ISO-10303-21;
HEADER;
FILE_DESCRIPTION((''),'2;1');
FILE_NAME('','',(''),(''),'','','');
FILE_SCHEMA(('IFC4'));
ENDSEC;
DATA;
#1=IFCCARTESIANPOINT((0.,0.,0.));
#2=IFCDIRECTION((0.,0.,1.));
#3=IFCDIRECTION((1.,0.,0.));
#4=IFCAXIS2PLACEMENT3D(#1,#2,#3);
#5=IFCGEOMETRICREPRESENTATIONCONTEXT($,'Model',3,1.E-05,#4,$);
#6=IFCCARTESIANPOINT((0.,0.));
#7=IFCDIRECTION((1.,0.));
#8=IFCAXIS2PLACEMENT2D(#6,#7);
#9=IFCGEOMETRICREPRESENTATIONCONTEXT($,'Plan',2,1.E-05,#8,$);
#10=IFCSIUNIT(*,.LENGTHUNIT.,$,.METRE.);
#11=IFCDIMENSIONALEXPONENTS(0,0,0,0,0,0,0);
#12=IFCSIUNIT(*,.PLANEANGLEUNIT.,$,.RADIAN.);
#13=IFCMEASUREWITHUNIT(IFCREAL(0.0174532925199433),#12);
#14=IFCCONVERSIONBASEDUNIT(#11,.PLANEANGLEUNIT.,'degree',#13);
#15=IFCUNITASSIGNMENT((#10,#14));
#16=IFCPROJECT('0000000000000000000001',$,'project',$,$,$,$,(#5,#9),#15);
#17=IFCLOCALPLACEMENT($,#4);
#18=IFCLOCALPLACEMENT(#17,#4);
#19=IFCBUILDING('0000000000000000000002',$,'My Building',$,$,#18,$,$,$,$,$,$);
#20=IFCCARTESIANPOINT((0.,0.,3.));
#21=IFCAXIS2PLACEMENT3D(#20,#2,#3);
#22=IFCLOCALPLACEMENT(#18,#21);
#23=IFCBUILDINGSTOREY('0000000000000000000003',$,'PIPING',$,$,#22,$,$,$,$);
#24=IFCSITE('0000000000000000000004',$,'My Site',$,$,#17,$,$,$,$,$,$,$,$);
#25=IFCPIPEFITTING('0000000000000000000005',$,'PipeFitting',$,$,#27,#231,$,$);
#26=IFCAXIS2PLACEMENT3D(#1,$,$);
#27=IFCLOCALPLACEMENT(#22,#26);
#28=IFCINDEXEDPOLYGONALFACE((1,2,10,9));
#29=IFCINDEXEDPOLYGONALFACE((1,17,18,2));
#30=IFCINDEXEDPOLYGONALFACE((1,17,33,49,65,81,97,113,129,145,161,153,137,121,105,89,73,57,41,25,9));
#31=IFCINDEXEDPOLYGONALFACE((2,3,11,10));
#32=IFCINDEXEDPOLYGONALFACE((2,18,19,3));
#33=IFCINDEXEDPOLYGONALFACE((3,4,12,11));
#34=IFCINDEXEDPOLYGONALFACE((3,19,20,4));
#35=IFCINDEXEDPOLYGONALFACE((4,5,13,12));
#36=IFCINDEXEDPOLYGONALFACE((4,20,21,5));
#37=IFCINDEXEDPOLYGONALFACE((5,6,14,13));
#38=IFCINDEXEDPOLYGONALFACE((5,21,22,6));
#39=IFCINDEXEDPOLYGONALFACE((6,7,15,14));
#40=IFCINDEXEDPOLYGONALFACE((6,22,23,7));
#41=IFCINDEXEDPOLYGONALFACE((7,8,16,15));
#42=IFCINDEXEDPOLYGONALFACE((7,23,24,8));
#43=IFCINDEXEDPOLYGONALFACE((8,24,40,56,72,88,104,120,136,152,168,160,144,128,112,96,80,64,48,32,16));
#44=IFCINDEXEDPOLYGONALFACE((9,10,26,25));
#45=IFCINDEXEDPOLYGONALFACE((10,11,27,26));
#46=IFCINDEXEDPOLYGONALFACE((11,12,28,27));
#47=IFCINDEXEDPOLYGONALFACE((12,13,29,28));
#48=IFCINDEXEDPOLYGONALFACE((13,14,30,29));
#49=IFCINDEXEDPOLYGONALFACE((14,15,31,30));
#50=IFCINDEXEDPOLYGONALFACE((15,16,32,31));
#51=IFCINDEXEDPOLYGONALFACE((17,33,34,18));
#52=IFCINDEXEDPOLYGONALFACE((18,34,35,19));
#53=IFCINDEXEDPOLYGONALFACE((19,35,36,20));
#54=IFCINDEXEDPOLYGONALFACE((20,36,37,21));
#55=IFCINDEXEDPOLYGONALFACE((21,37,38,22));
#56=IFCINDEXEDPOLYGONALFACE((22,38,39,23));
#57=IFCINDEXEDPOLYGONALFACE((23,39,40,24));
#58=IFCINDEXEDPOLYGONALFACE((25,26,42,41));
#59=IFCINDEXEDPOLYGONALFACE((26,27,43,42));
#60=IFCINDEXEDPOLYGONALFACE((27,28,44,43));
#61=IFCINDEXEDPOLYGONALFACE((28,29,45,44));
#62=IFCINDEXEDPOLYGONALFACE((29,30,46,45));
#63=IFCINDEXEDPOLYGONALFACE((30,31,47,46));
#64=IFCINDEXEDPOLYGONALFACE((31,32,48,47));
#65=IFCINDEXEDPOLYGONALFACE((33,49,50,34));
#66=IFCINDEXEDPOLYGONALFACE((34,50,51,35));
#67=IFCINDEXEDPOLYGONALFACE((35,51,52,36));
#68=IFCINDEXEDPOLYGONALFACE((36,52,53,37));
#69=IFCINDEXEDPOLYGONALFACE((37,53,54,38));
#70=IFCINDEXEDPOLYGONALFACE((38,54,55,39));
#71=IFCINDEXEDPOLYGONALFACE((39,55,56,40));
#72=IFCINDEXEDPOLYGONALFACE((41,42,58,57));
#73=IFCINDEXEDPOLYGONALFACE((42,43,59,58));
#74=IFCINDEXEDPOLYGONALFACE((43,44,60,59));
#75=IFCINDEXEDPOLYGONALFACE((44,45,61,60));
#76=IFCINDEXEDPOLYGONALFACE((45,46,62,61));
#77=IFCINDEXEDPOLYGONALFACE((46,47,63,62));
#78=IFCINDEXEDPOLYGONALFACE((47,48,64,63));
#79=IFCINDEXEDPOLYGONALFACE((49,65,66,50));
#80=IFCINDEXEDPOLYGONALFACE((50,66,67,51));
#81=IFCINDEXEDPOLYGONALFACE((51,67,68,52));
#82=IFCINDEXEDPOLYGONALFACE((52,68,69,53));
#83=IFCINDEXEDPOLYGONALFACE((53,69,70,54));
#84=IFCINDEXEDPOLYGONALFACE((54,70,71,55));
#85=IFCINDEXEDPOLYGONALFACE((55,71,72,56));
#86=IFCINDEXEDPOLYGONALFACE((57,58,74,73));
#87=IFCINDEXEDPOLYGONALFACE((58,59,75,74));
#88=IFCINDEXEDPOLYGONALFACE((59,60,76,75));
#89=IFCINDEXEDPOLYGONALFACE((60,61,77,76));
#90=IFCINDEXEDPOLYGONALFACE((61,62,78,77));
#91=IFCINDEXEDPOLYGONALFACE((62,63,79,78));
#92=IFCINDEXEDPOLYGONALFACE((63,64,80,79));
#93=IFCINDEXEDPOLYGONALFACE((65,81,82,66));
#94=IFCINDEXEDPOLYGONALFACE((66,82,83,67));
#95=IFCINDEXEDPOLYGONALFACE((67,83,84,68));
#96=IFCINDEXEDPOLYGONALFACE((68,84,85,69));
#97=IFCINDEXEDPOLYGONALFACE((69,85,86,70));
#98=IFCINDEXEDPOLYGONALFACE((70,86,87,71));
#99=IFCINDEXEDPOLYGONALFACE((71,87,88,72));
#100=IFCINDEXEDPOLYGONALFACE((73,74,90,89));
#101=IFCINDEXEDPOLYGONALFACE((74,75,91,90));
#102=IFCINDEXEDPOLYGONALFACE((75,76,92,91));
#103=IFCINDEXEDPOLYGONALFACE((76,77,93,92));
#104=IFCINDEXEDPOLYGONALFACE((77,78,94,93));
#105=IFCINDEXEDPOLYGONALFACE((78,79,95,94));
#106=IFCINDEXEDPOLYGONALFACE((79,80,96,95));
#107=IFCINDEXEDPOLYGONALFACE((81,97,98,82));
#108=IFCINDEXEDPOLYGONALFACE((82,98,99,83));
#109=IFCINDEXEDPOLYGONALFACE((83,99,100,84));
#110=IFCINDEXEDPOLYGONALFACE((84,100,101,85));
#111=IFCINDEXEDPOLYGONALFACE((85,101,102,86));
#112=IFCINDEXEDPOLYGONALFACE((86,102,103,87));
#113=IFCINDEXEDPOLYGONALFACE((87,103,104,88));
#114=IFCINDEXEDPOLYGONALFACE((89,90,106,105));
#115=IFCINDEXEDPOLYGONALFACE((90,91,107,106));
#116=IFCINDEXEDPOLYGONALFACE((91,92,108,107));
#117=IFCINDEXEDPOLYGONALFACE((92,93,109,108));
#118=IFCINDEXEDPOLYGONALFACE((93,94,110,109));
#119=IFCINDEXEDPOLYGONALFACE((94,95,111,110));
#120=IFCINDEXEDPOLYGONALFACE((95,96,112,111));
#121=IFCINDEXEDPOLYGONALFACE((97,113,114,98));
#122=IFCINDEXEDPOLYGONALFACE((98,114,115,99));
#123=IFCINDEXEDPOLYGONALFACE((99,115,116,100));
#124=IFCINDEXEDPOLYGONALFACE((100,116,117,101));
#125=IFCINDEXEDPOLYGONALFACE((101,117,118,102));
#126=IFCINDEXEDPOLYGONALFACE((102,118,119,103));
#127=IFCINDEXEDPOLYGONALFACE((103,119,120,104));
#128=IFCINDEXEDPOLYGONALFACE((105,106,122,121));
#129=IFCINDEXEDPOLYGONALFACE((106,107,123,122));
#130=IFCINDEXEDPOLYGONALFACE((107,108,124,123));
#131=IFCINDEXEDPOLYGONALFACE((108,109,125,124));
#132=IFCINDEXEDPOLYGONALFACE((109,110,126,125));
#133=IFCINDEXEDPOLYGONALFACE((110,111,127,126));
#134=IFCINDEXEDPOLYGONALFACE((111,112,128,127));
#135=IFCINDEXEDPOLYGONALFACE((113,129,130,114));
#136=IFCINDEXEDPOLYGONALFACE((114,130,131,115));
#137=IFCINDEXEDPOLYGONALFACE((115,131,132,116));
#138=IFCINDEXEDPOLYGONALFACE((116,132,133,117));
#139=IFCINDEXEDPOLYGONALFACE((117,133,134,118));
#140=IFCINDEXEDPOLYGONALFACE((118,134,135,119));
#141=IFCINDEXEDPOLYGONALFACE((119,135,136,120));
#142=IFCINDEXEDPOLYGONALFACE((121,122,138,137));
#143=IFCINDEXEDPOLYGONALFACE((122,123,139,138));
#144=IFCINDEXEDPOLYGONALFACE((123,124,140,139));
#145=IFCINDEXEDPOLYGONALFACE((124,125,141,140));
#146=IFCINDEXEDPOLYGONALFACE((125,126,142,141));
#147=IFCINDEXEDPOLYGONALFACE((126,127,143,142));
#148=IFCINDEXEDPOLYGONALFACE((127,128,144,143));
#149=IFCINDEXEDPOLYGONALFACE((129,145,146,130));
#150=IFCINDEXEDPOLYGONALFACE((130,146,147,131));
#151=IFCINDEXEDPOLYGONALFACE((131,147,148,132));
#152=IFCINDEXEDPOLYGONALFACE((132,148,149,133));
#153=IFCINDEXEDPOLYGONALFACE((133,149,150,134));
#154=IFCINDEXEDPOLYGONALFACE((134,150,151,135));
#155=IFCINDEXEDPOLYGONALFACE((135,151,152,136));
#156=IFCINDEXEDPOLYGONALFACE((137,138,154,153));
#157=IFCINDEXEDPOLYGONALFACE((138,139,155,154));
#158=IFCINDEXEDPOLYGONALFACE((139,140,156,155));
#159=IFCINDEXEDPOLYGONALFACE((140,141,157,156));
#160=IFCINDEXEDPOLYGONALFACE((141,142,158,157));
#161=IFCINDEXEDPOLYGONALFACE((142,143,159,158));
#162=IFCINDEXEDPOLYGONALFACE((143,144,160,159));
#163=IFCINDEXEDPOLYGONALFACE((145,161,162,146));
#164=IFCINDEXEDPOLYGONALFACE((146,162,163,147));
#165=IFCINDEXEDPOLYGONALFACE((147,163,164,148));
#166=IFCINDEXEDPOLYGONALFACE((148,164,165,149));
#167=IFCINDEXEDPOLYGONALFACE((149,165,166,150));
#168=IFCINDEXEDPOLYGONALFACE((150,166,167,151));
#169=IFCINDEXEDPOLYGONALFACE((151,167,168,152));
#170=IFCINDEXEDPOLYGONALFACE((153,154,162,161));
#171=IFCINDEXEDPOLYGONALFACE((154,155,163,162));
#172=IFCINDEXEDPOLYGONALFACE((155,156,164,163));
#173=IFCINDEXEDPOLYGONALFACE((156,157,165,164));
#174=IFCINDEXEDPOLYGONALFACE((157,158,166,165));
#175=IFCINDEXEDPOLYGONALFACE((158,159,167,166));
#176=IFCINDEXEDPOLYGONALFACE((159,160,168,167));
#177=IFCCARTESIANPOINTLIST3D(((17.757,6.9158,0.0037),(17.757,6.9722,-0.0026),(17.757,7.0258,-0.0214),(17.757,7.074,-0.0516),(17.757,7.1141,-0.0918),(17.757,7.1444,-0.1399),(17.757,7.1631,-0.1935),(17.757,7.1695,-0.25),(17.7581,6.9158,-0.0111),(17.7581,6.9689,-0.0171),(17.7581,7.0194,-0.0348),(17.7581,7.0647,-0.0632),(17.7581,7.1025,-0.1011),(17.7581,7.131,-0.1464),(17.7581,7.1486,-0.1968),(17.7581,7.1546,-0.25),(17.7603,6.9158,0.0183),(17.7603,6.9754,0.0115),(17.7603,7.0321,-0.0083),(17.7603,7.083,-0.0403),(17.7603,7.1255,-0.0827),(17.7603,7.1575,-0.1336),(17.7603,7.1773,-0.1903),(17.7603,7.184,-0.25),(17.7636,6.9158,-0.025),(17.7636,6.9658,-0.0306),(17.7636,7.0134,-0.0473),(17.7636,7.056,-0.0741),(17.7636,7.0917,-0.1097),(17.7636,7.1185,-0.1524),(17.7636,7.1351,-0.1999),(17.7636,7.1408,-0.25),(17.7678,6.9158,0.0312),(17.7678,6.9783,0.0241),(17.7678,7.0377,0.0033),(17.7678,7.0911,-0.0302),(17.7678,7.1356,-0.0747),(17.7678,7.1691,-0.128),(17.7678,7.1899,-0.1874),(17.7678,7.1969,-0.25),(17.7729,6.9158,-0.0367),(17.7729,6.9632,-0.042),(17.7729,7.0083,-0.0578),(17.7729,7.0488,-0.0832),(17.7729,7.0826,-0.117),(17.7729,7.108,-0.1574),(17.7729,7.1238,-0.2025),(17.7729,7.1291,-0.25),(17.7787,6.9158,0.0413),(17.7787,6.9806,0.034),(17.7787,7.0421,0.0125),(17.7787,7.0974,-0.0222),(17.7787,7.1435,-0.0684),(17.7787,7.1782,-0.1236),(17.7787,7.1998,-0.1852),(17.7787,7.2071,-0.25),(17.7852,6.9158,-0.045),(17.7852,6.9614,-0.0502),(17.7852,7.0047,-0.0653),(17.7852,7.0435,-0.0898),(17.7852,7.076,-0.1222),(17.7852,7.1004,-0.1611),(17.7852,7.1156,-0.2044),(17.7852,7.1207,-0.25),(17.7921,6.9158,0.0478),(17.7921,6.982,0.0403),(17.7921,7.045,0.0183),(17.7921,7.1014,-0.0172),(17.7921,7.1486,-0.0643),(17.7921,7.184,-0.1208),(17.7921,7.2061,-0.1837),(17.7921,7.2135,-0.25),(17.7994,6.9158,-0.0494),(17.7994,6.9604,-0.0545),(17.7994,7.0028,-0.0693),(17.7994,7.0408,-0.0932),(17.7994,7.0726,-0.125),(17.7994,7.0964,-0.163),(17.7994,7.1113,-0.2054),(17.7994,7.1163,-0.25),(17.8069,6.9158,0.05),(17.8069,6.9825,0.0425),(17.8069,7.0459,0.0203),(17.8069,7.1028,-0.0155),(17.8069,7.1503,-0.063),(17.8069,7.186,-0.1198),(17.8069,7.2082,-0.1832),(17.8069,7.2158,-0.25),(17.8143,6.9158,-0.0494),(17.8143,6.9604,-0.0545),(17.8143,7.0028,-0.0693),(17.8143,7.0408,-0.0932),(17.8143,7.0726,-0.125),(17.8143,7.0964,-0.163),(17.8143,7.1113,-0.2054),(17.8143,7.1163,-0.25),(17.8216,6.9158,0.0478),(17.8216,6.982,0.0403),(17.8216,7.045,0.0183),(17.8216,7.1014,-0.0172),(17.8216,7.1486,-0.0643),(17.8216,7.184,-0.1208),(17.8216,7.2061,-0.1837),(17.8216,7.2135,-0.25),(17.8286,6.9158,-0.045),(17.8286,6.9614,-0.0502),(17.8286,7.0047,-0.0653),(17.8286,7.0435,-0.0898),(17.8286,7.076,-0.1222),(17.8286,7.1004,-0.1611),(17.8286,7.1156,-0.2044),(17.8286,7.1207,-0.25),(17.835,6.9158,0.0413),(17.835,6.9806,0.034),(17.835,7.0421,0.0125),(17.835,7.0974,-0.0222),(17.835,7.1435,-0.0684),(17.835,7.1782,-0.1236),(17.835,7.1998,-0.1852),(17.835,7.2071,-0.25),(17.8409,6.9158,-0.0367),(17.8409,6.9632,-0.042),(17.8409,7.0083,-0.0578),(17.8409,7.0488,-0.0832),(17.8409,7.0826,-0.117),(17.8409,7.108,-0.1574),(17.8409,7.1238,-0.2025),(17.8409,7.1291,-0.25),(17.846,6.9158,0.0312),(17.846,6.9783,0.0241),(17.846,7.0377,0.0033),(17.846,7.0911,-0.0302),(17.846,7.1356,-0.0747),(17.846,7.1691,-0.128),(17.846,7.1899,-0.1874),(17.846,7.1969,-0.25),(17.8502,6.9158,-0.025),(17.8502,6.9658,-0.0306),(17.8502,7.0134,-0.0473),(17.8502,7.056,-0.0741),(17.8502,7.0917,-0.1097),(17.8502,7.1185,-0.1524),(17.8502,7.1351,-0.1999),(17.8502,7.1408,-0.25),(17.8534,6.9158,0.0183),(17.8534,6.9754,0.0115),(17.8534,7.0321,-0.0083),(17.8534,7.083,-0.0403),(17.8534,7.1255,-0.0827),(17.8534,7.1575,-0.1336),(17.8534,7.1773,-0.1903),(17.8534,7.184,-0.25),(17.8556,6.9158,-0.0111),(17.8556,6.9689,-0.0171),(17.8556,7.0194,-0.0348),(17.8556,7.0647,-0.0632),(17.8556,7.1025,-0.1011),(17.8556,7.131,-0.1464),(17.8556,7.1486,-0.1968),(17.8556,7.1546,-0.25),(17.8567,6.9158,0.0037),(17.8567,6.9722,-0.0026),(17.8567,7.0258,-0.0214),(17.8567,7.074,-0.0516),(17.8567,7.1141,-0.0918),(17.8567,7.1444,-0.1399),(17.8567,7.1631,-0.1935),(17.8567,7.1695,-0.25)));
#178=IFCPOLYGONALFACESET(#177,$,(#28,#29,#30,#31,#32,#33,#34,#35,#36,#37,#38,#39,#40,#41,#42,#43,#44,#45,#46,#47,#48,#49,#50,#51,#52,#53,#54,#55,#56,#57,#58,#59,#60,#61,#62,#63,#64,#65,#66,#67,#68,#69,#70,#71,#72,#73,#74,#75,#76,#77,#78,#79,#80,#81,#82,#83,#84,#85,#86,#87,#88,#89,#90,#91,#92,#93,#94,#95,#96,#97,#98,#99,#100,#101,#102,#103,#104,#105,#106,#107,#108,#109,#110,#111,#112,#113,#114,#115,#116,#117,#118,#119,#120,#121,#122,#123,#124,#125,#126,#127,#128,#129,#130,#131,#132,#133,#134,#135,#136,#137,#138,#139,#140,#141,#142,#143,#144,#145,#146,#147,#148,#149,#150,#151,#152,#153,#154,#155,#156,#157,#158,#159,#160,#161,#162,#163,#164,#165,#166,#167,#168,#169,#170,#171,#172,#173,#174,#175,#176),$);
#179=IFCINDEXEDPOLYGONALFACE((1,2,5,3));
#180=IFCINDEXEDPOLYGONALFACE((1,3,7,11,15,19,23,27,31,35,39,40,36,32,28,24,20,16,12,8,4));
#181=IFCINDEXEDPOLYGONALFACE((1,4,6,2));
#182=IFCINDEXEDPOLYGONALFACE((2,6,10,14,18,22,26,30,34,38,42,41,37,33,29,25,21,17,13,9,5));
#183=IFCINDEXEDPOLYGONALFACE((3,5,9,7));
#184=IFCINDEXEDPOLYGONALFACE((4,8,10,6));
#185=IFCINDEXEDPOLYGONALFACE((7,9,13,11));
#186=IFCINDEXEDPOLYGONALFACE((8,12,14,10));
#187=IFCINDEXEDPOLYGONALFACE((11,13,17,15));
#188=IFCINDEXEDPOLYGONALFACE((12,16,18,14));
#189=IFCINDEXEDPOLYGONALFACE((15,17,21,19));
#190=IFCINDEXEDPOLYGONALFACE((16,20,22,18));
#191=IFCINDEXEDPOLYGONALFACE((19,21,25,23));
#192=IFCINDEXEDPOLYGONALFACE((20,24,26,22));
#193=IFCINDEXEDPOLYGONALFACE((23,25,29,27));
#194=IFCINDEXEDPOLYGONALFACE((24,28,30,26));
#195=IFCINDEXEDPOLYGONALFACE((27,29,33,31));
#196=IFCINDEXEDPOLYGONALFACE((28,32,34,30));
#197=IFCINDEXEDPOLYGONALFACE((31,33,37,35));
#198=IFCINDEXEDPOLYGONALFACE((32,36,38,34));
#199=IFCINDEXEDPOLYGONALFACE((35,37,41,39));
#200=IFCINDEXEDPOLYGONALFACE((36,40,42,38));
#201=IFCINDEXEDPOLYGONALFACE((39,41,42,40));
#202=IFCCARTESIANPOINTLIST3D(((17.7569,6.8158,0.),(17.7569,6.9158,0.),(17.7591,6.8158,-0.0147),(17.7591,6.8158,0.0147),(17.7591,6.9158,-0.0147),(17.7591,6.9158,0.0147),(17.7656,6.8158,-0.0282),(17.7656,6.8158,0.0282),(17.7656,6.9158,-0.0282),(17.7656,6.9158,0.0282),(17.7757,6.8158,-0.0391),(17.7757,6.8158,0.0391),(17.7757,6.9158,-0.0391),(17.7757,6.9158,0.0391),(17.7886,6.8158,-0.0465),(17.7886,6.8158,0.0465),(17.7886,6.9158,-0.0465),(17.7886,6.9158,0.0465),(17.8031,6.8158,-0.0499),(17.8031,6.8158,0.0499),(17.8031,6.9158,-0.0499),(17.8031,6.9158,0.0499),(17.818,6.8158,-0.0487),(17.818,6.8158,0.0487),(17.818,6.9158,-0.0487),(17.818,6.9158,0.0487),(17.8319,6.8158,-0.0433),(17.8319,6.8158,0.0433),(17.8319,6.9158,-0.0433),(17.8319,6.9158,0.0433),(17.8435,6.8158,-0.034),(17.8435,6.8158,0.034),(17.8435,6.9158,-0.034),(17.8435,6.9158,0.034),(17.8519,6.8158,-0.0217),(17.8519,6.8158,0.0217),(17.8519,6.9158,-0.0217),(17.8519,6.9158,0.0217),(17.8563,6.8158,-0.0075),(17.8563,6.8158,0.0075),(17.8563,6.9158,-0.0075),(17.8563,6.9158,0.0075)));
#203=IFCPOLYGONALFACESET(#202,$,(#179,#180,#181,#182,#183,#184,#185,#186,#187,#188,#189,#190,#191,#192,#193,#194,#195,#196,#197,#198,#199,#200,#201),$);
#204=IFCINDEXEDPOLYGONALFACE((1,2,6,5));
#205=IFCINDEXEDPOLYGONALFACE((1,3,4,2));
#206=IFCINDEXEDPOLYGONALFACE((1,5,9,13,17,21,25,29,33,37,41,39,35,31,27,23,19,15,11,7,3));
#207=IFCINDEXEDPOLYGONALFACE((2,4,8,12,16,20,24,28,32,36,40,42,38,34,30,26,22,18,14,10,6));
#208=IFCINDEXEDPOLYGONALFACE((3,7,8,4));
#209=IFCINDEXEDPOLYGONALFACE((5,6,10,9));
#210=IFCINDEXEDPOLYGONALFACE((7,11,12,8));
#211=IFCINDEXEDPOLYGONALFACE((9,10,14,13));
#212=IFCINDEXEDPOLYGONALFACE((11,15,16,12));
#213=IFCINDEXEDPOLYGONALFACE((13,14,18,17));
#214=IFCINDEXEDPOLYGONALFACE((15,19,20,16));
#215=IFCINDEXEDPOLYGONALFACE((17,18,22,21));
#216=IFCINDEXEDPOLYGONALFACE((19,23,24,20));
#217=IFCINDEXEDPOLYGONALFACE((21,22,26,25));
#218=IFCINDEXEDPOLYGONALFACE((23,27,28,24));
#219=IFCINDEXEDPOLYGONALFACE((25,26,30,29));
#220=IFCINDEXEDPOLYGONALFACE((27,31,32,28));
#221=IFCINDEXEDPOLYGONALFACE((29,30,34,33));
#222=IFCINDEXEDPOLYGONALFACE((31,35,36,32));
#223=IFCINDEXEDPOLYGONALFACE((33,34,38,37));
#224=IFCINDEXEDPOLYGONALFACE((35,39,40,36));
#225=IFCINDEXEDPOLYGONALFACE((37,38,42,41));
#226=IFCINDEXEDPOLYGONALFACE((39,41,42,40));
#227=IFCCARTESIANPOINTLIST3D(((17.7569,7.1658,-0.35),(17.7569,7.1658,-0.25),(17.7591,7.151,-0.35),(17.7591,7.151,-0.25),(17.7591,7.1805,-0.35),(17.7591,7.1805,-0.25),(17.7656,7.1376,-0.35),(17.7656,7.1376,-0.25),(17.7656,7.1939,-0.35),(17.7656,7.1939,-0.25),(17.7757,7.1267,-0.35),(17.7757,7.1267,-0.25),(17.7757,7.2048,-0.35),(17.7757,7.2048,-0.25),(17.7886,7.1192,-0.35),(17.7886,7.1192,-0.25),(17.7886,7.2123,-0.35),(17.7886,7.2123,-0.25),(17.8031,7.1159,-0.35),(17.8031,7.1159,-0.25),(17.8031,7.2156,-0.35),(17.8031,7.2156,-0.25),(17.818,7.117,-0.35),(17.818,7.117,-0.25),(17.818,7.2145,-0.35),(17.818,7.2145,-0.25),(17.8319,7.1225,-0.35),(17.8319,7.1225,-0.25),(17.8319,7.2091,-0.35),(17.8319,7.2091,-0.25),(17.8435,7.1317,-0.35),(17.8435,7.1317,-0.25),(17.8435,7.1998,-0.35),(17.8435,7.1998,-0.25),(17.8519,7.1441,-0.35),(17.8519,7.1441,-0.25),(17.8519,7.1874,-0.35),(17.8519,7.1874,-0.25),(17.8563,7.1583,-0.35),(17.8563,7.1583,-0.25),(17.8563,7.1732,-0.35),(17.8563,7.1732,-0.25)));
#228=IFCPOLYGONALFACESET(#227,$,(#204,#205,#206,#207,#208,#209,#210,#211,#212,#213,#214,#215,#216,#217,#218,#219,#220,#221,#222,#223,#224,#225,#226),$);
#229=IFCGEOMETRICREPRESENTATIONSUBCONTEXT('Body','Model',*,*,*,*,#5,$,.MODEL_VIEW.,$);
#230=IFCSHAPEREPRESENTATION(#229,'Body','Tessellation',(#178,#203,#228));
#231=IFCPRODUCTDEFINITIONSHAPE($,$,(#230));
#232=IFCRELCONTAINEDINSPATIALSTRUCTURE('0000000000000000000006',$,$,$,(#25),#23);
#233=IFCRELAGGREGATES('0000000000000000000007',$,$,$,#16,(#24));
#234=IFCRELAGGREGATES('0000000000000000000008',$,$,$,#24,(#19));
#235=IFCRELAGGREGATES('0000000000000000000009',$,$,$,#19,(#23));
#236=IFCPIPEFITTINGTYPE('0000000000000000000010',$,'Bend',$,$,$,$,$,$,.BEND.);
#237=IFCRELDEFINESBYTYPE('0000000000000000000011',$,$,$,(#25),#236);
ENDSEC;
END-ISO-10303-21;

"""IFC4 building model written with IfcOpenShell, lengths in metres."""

from ifc_helpers import new_model, entity, si_unit, converted_unit, frame, origin_with_axes, origin_2d_with_axis, place, context, subcontext, project, spatial, line, indexed_curve, circle, outline, extrude, source, transform, mapped, type_object, type_shapes, element, save


model = new_model("IFC4")

# Units and contexts
model_context = context("Model", 3, precision=1e-05, world=origin_with_axes())
plan_context = context("Plan", 2, precision=1e-05, world=origin_2d_with_axis())
body_context = subcontext(model_context, "Body", "Model", "MODEL_VIEW")
ifc_project = project(units=[si_unit("LENGTHUNIT", "METRE"), converted_unit("PLANEANGLEUNIT", "degree", entity("IfcReal", 0.0174532925199433), si_unit("PLANEANGLEUNIT", "RADIAN"), dimensions=[0, 0, 0, 0, 0, 0, 0])], contexts=[model_context, plan_context])

# Site, building, storey
site_placement = place(None, origin_with_axes())
site = spatial("IfcSite", under=ifc_project, at=site_placement, Name="My Site")
building_placement = place(site_placement, origin_with_axes())
building = spatial("IfcBuilding", under=site, at=building_placement, Name="My Building")
storey_placement = place(building_placement, frame((0.0, 0.0, 3.0), z_axis=(0.0, 0.0, 1.0), x_axis=(1.0, 0.0, 0.0)))
storey = spatial("IfcBuildingStorey", under=building, at=storey_placement, Name="PIPING")

# Pipe fitting, opening
pipe_fitting_type = type_object("IfcPipeFittingType", Name="Bend", PredefinedType="BEND")
shared_shape = source(origin_with_axes(), body_context, "Body", "SolidModel", [
    entity("IfcSweptDiskSolid", entity("IfcIndexedPolyCurve", entity("IfcCartesianPointList3D", [[0.0, 0.0, 0.1], [0.0, -0.0732, 0.2768], [0.0, -0.25, 0.35]]), [entity("IfcArcIndex", [1, 2, 3])]), 0.05),
    extrude(circle(Radius=0.05), origin_with_axes(), (0.0, 0.0, 1.0), 0.1),
    extrude(circle(Radius=0.05), frame((0.0, -0.25, 0.35), z_axis=(0.0, -1.0, 0.0), x_axis=(1.0, 0.0, 0.0)), (0.0, 0.0, 1.0), 0.1),
])
type_shapes(pipe_fitting_type, [shared_shape])
pipe_fitting_1_placement = place(storey_placement, frame((17.8069, 6.8158, 0.0), z_axis=(0.0, 1.0, 0.0), x_axis=(-1.0, 0.0, 0.0)))
pipe_fitting_1 = element("IfcPipeFitting", 1, at=pipe_fitting_1_placement, inside=storey, type_object=pipe_fitting_type, Name="PipeFitting", context=body_context, shape_type="MappedRepresentation", body=[
    mapped(shared_shape, transform((0.0, 0.0, 0.0), x_axis=(1.0, 0.0, 0.0), y_axis=(0.0, 1.0, 0.0), z_axis=(0.0, 0.0, 1.0), scale=1.0)),
])
opening_1_placement = place(pipe_fitting_1_placement, frame((17.8069, -3.0, -6.8158), z_axis=(0.0, 1.0, 0.0), x_axis=(-1.0, 0.0, 0.0)))
element("IfcOpeningElement", 2, at=opening_1_placement, cuts=pipe_fitting_1, PredefinedType="OPENING", context=body_context, shape_type="SweptSolid", body=[
    extrude(outline(indexed_curve([(0.0, 0.0), (0.5, 0.0), (0.5, 0.5), (0.0, 0.5)], segments=[line(1, 2, 3, 4, 1)])), origin_with_axes(), (0.0, 0.0, 1.0), 0.5),
])

save(model, "model.ifc")
